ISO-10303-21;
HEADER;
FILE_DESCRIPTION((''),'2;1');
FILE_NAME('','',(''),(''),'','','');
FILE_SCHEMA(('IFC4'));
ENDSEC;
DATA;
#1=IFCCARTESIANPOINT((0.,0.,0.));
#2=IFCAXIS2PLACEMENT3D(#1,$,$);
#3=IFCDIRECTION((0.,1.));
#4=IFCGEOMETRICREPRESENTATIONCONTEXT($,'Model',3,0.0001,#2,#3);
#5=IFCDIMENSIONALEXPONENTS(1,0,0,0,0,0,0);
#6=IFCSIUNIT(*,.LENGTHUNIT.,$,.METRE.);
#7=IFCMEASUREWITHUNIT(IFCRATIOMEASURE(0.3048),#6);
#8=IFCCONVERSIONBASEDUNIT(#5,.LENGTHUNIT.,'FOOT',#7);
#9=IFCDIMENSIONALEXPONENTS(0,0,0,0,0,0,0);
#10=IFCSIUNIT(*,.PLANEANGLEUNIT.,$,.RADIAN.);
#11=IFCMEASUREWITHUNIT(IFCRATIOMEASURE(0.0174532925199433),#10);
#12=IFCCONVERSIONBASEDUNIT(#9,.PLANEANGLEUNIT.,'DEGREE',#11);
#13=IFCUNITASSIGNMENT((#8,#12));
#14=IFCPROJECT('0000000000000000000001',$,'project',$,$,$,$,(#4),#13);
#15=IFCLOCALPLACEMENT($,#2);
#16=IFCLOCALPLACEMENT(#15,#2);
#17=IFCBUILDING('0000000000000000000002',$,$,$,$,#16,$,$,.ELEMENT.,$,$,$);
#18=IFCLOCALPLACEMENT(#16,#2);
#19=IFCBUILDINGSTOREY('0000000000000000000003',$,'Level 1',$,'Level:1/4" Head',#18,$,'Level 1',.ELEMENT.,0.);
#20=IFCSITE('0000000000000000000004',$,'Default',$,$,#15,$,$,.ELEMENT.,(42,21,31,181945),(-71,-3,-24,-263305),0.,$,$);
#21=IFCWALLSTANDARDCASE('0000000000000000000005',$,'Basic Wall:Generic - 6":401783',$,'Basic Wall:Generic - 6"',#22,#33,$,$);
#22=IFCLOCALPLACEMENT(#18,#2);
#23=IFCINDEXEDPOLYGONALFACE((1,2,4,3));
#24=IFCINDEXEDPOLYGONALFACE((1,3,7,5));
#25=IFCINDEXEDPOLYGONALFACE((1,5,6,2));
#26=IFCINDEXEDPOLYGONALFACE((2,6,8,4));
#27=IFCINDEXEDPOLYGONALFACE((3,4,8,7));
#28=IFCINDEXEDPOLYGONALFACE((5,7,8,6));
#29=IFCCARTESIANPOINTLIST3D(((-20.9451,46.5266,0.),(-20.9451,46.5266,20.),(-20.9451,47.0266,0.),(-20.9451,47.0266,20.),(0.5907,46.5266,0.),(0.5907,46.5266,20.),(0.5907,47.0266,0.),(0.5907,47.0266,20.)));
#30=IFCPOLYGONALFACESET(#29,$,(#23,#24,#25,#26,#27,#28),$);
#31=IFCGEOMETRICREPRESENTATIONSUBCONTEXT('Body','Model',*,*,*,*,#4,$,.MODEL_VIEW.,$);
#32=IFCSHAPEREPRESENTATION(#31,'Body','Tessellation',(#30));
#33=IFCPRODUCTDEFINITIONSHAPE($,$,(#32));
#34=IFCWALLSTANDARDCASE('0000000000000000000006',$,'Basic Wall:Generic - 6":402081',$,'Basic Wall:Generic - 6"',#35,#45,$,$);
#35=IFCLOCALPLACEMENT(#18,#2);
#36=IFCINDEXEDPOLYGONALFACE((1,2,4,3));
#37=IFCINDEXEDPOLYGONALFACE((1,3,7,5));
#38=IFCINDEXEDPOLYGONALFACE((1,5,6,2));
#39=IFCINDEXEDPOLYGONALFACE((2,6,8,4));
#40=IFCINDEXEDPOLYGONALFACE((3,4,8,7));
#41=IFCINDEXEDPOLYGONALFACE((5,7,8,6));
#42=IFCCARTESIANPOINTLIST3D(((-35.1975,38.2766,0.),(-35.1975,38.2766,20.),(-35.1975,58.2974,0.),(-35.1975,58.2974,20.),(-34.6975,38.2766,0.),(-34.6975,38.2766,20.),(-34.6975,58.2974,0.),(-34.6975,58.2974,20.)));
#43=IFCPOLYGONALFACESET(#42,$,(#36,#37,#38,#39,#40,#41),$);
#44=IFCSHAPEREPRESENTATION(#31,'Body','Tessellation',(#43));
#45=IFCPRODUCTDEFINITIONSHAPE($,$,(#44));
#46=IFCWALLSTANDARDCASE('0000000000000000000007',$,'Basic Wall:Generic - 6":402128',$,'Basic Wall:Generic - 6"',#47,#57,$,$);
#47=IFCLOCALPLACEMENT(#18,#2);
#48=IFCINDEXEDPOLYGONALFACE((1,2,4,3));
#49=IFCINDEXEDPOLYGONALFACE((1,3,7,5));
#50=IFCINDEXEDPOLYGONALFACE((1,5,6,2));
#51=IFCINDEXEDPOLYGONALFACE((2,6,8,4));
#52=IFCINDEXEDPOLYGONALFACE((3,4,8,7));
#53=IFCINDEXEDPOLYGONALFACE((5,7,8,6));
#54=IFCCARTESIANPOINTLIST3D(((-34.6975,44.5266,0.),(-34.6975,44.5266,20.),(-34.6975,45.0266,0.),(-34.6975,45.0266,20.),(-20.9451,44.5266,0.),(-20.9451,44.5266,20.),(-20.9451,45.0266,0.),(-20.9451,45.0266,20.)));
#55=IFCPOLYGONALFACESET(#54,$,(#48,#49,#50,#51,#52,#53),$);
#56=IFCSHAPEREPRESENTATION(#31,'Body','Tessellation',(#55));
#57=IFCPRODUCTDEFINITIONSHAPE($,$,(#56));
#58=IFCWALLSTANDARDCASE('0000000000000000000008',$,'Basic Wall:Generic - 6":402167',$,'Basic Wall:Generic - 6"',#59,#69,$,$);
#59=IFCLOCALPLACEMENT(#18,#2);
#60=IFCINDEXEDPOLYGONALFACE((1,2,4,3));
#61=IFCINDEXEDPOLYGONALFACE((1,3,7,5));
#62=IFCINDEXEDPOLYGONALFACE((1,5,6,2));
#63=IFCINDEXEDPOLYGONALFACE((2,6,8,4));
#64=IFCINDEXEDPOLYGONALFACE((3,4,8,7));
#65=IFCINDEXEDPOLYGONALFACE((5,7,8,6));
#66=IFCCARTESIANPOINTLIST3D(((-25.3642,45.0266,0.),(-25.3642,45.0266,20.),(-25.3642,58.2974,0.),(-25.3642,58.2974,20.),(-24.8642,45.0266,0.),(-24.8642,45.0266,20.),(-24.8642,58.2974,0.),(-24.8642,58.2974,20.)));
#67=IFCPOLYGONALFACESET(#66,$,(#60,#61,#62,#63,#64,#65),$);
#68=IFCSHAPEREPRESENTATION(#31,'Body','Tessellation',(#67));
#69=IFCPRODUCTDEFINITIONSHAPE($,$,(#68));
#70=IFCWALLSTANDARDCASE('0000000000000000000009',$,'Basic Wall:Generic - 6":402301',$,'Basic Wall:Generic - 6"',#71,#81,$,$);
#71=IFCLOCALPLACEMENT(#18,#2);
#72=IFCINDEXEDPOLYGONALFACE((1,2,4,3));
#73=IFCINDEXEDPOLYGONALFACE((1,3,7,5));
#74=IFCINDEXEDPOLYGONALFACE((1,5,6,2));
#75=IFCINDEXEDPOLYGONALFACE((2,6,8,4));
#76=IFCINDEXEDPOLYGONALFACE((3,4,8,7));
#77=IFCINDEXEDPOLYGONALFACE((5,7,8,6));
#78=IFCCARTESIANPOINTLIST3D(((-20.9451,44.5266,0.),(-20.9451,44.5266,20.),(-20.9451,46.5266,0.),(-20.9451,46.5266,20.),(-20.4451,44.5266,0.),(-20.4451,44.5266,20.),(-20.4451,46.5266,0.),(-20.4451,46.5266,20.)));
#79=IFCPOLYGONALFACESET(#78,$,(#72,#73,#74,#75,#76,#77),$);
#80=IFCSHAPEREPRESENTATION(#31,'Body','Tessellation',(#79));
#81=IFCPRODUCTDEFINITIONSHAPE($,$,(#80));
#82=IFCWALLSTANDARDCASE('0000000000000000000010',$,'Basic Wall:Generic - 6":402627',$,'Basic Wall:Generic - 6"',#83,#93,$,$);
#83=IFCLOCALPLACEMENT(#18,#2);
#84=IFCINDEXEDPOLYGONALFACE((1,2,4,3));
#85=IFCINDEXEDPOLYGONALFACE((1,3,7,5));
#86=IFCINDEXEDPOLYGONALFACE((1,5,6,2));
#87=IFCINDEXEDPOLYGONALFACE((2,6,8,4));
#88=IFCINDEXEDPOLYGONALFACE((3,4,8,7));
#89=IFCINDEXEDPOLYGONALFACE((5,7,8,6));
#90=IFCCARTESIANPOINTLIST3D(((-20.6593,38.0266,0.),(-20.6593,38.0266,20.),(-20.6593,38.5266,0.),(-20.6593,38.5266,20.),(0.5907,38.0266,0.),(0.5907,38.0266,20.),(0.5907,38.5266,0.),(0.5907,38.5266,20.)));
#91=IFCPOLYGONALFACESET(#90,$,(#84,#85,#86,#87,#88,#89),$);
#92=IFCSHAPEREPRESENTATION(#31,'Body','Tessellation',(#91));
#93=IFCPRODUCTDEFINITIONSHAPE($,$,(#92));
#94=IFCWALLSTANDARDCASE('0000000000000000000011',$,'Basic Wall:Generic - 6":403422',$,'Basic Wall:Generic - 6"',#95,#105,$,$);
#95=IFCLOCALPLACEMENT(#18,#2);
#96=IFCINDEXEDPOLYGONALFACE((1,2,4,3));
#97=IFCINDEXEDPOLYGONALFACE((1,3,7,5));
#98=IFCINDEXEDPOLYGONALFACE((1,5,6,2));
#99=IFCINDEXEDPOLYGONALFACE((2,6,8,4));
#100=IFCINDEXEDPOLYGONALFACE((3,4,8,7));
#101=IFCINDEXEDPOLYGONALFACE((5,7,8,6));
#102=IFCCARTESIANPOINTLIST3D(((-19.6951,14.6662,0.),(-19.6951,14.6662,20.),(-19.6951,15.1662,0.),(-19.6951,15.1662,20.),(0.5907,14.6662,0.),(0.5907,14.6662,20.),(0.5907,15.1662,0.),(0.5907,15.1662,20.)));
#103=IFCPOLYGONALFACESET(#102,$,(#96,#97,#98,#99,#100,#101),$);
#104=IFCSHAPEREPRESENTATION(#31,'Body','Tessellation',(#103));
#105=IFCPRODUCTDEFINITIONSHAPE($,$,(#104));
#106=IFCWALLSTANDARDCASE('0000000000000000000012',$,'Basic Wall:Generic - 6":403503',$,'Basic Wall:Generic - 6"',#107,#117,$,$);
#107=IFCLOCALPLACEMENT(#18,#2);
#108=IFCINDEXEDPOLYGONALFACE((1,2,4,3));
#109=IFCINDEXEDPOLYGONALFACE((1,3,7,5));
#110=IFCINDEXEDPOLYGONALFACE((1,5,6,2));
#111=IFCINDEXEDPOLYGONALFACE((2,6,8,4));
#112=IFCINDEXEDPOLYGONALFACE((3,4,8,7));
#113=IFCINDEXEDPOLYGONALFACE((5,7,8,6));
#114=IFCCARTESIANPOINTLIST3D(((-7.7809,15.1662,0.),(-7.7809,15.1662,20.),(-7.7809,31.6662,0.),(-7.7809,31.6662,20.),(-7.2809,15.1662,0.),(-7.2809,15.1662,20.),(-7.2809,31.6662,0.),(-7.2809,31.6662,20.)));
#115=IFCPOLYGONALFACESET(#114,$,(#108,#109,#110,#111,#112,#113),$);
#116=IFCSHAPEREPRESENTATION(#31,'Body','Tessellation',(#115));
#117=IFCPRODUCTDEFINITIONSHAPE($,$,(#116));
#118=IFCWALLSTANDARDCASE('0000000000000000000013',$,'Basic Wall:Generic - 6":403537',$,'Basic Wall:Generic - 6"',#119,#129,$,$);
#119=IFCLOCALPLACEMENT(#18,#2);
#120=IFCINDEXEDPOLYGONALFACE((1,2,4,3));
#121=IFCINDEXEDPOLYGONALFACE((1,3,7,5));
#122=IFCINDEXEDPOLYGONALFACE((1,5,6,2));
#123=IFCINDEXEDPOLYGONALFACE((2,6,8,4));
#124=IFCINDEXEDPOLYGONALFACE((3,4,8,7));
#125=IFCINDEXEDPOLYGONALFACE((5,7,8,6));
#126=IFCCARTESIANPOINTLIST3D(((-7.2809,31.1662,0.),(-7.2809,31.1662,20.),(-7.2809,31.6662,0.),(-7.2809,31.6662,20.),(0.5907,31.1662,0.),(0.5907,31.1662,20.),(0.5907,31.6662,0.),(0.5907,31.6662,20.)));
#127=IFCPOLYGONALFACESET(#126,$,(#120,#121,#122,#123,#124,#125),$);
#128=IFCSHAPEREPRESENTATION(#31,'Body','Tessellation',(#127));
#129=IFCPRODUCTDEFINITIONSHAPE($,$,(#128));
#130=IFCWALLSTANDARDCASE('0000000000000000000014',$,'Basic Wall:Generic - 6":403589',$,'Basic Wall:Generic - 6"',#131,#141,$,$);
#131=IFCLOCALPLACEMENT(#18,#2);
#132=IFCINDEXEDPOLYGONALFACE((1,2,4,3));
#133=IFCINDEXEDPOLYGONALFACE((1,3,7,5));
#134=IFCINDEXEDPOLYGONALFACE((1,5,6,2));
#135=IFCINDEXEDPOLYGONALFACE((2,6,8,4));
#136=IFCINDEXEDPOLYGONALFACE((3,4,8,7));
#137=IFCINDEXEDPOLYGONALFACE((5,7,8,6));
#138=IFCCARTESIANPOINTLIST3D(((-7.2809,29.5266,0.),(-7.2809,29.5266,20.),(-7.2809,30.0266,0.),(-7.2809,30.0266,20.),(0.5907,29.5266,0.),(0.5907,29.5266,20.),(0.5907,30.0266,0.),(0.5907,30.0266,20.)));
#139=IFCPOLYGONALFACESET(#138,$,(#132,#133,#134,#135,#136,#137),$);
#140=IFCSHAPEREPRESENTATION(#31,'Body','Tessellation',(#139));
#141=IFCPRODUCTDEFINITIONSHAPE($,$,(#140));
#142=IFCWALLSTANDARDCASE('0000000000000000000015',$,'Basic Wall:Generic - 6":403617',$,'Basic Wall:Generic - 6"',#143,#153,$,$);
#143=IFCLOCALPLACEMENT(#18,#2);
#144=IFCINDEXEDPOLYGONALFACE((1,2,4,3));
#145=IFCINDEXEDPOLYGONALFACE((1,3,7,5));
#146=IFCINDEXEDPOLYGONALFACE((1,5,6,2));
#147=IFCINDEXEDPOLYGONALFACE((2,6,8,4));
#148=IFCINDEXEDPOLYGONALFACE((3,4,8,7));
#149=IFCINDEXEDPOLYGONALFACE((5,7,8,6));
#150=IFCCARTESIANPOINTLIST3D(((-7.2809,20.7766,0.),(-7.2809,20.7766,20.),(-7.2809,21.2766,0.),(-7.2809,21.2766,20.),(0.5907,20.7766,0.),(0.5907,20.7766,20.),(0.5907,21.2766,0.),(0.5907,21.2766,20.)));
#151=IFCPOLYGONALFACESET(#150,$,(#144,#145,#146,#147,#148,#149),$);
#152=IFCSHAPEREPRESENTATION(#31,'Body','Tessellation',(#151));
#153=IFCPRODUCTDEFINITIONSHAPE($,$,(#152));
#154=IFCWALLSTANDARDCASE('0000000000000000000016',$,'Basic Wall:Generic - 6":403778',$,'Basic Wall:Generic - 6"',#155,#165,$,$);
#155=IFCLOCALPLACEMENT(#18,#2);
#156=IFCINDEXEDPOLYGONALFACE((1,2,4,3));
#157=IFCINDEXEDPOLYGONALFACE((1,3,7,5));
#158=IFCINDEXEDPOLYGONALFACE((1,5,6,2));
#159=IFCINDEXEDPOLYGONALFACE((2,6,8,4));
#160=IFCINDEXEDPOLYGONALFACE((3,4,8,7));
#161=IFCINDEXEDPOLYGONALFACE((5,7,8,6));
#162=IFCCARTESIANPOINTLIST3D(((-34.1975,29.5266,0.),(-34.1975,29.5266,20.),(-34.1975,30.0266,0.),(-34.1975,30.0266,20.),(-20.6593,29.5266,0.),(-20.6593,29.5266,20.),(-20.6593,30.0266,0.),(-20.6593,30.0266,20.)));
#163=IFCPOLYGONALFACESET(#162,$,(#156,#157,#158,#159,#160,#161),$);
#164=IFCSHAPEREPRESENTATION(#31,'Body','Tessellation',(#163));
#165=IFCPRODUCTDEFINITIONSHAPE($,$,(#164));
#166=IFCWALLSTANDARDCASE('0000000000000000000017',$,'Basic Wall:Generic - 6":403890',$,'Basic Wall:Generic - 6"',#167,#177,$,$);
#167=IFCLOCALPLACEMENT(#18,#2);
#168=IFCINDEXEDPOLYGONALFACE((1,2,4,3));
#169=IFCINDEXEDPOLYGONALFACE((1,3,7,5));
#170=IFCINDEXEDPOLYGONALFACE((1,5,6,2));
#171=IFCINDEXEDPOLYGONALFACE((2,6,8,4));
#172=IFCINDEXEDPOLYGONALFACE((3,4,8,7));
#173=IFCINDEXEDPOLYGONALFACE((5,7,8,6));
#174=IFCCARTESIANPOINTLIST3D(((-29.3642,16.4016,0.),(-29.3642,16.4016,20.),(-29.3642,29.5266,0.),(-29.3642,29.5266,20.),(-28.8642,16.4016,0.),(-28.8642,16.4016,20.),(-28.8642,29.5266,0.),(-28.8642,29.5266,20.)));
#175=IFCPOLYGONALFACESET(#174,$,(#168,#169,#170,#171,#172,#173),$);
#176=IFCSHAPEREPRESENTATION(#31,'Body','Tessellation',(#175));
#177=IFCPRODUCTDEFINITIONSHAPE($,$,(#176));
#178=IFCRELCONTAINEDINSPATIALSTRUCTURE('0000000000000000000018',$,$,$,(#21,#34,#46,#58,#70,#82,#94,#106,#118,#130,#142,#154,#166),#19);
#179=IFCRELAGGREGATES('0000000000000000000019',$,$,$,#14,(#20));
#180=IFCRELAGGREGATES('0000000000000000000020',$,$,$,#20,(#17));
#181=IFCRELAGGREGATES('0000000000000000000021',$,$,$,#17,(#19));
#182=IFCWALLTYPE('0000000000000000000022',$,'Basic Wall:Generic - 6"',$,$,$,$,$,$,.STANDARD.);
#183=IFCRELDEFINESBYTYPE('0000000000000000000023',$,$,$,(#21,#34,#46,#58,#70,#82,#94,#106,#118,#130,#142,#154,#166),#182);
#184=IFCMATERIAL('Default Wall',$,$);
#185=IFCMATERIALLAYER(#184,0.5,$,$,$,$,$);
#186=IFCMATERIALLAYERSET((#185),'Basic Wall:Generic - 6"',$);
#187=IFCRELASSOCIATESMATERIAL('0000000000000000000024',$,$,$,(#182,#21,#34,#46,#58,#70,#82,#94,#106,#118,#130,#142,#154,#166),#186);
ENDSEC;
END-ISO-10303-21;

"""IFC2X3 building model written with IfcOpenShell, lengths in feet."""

from ifc_helpers import new_model, entity, si_unit, converted_unit, direction, frame, frame_2d, origin, place, context, subcontext, project, spatial, rectangle, extrude, material, layer, layer_set, layer_usage, type_object, element, save


model = new_model("IFC2X3")

# Units and contexts
model_context = context("Model", 3, precision=0.0001, world=origin(), true_north=direction((0.0, 1.0)))
body_context = subcontext(model_context, "Body", "Model", "MODEL_VIEW")
ifc_project = project(units=[converted_unit("LENGTHUNIT", "FOOT", entity("IfcRatioMeasure", 0.3048), si_unit("LENGTHUNIT", "METRE"), dimensions=[1, 0, 0, 0, 0, 0, 0]), converted_unit("PLANEANGLEUNIT", "DEGREE", entity("IfcRatioMeasure", 0.0174532925199433), si_unit("PLANEANGLEUNIT", "RADIAN"), dimensions=[0, 0, 0, 0, 0, 0, 0])], contexts=[model_context])

# Site, building, storey
site_placement = place(None, origin())
site = spatial("IfcSite", under=ifc_project, at=site_placement, Name="Default", CompositionType="ELEMENT", RefLatitude=(42, 21, 31, 181945), RefLongitude=(-71, -3, -24, -263305), RefElevation=0.0)
building_placement = place(site_placement, origin())
building = spatial("IfcBuilding", under=site, at=building_placement, CompositionType="ELEMENT")
storey_placement = place(building_placement, origin())
storey = spatial("IfcBuildingStorey", under=building, at=storey_placement, Name="Level 1", ObjectType="Level:1/4\" Head", LongName="Level 1", CompositionType="ELEMENT", Elevation=0.0)

# Walls
ifc_material = material(Name="Default Wall")
ifc_layer_1 = layer(ifc_material, 0.5)
ifc_layer_set_1 = layer_set([ifc_layer_1], Name="Basic Wall:Generic - 6\"")
wall_type_1 = type_object("IfcWallType", Name="Basic Wall:Generic - 6\"", PredefinedType="STANDARD", material=ifc_layer_set_1)
ifc_layer_usage_1 = layer_usage(ifc_layer_set_1, "AXIS2", "NEGATIVE", 0.25)
wall_1_placement = place(storey_placement, frame((-20.9451, 46.7766, 0.0)))
element("IfcWallStandardCase", 1, at=wall_1_placement, inside=storey, type_object=wall_type_1, material=ifc_layer_usage_1, Name="Basic Wall:Generic - 6\":401783", ObjectType="Basic Wall:Generic - 6\"", context=body_context, shape_type="SweptSolid", body=[
    extrude(rectangle(XDim=21.5358, YDim=0.5, at=frame_2d((10.7679, 0.0), x_axis=(-1.0, 0.0))), origin(), (0.0, 0.0, 1.0), 20.0),
])
ifc_layer_usage_2 = layer_usage(ifc_layer_set_1, "AXIS2", "NEGATIVE", 0.25)
wall_2_placement = place(storey_placement, frame((-34.9475, 58.2974, 0.0), z_axis=(0.0, 0.0, 1.0), x_axis=(0.0, -1.0, 0.0)))
element("IfcWallStandardCase", 2, at=wall_2_placement, inside=storey, type_object=wall_type_1, material=ifc_layer_usage_2, Name="Basic Wall:Generic - 6\":402081", ObjectType="Basic Wall:Generic - 6\"", context=body_context, shape_type="SweptSolid", body=[
    extrude(rectangle(XDim=20.0208, YDim=0.5, at=frame_2d((10.0104, 0.0), x_axis=(-1.0, 0.0))), origin(), (0.0, 0.0, 1.0), 20.0),
])
ifc_layer_usage_3 = layer_usage(ifc_layer_set_1, "AXIS2", "NEGATIVE", 0.25)
wall_3_placement = place(storey_placement, frame((-34.6975, 44.7766, 0.0)))
element("IfcWallStandardCase", 3, at=wall_3_placement, inside=storey, type_object=wall_type_1, material=ifc_layer_usage_3, Name="Basic Wall:Generic - 6\":402128", ObjectType="Basic Wall:Generic - 6\"", context=body_context, shape_type="SweptSolid", body=[
    extrude(rectangle(XDim=13.7524, YDim=0.5, at=frame_2d((6.8762, 0.0), x_axis=(-1.0, 0.0))), origin(), (0.0, 0.0, 1.0), 20.0),
])
ifc_layer_usage_4 = layer_usage(ifc_layer_set_1, "AXIS2", "NEGATIVE", 0.25)
wall_4_placement = place(storey_placement, frame((-25.1142, 45.0266, 0.0), z_axis=(0.0, 0.0, 1.0), x_axis=(0.0, 1.0, 0.0)))
element("IfcWallStandardCase", 4, at=wall_4_placement, inside=storey, type_object=wall_type_1, material=ifc_layer_usage_4, Name="Basic Wall:Generic - 6\":402167", ObjectType="Basic Wall:Generic - 6\"", context=body_context, shape_type="SweptSolid", body=[
    extrude(rectangle(XDim=13.2708, YDim=0.5, at=frame_2d((6.6354, 0.0), x_axis=(-1.0, 0.0))), origin(), (0.0, 0.0, 1.0), 20.0),
])
ifc_layer_usage_5 = layer_usage(ifc_layer_set_1, "AXIS2", "NEGATIVE", 0.25)
wall_5_placement = place(storey_placement, frame((-20.6951, 46.5266, 0.0), z_axis=(0.0, 0.0, 1.0), x_axis=(0.0, -1.0, 0.0)))
element("IfcWallStandardCase", 5, at=wall_5_placement, inside=storey, type_object=wall_type_1, material=ifc_layer_usage_5, Name="Basic Wall:Generic - 6\":402301", ObjectType="Basic Wall:Generic - 6\"", context=body_context, shape_type="SweptSolid", body=[
    extrude(rectangle(XDim=2.0, YDim=0.5, at=frame_2d((1.0, 0.0), x_axis=(-1.0, 0.0))), origin(), (0.0, 0.0, 1.0), 20.0),
])
ifc_layer_usage_6 = layer_usage(ifc_layer_set_1, "AXIS2", "NEGATIVE", 0.25)
wall_6_placement = place(storey_placement, frame((0.5907, 38.2766, 0.0), z_axis=(0.0, 0.0, 1.0), x_axis=(-1.0, 0.0, 0.0)))
element("IfcWallStandardCase", 6, at=wall_6_placement, inside=storey, type_object=wall_type_1, material=ifc_layer_usage_6, Name="Basic Wall:Generic - 6\":402627", ObjectType="Basic Wall:Generic - 6\"", context=body_context, shape_type="SweptSolid", body=[
    extrude(rectangle(XDim=21.25, YDim=0.5, at=frame_2d((10.625, 0.0), x_axis=(-1.0, 0.0))), origin(), (0.0, 0.0, 1.0), 20.0),
])
ifc_layer_usage_7 = layer_usage(ifc_layer_set_1, "AXIS2", "NEGATIVE", 0.25)
wall_7_placement = place(storey_placement, frame((0.5907, 14.9162, 0.0), z_axis=(0.0, 0.0, 1.0), x_axis=(-1.0, 0.0, 0.0)))
element("IfcWallStandardCase", 7, at=wall_7_placement, inside=storey, type_object=wall_type_1, material=ifc_layer_usage_7, Name="Basic Wall:Generic - 6\":403422", ObjectType="Basic Wall:Generic - 6\"", context=body_context, shape_type="SweptSolid", body=[
    extrude(rectangle(XDim=20.2858, YDim=0.5, at=frame_2d((10.1429, 0.0), x_axis=(-1.0, 0.0))), origin(), (0.0, 0.0, 1.0), 20.0),
])
ifc_layer_usage_8 = layer_usage(ifc_layer_set_1, "AXIS2", "NEGATIVE", 0.25)
wall_8_placement = place(storey_placement, frame((-7.5309, 15.1662, 0.0), z_axis=(0.0, 0.0, 1.0), x_axis=(0.0, 1.0, 0.0)))
element("IfcWallStandardCase", 8, at=wall_8_placement, inside=storey, type_object=wall_type_1, material=ifc_layer_usage_8, Name="Basic Wall:Generic - 6\":403503", ObjectType="Basic Wall:Generic - 6\"", context=body_context, shape_type="SweptSolid", body=[
    extrude(rectangle(XDim=16.5, YDim=0.5, at=frame_2d((8.25, 0.0), x_axis=(-1.0, 0.0))), origin(), (0.0, 0.0, 1.0), 20.0),
])
ifc_layer_usage_9 = layer_usage(ifc_layer_set_1, "AXIS2", "NEGATIVE", 0.25)
wall_9_placement = place(storey_placement, frame((-7.2809, 31.4162, 0.0)))
element("IfcWallStandardCase", 9, at=wall_9_placement, inside=storey, type_object=wall_type_1, material=ifc_layer_usage_9, Name="Basic Wall:Generic - 6\":403537", ObjectType="Basic Wall:Generic - 6\"", context=body_context, shape_type="SweptSolid", body=[
    extrude(rectangle(XDim=7.8716, YDim=0.5, at=frame_2d((3.9358, 0.0), x_axis=(-1.0, 0.0))), origin(), (0.0, 0.0, 1.0), 20.0),
])
ifc_layer_usage_10 = layer_usage(ifc_layer_set_1, "AXIS2", "NEGATIVE", 0.25)
wall_10_placement = place(storey_placement, frame((0.5907, 29.7766, 0.0), z_axis=(0.0, 0.0, 1.0), x_axis=(-1.0, 0.0, 0.0)))
element("IfcWallStandardCase", 10, at=wall_10_placement, inside=storey, type_object=wall_type_1, material=ifc_layer_usage_10, Name="Basic Wall:Generic - 6\":403589", ObjectType="Basic Wall:Generic - 6\"", context=body_context, shape_type="SweptSolid", body=[
    extrude(rectangle(XDim=7.8716, YDim=0.5, at=frame_2d((3.9358, 0.0), x_axis=(-1.0, 0.0))), origin(), (0.0, 0.0, 1.0), 20.0),
])
ifc_layer_usage_11 = layer_usage(ifc_layer_set_1, "AXIS2", "NEGATIVE", 0.25)
wall_11_placement = place(storey_placement, frame((-7.2809, 21.0266, 0.0)))
element("IfcWallStandardCase", 11, at=wall_11_placement, inside=storey, type_object=wall_type_1, material=ifc_layer_usage_11, Name="Basic Wall:Generic - 6\":403617", ObjectType="Basic Wall:Generic - 6\"", context=body_context, shape_type="SweptSolid", body=[
    extrude(rectangle(XDim=7.8716, YDim=0.5, at=frame_2d((3.9358, 0.0), x_axis=(-1.0, 0.0))), origin(), (0.0, 0.0, 1.0), 20.0),
])
ifc_layer_usage_12 = layer_usage(ifc_layer_set_1, "AXIS2", "NEGATIVE", 0.25)
wall_12_placement = place(storey_placement, frame((-20.6593, 29.7766, 0.0), z_axis=(0.0, 0.0, 1.0), x_axis=(-1.0, 0.0, 0.0)))
element("IfcWallStandardCase", 12, at=wall_12_placement, inside=storey, type_object=wall_type_1, material=ifc_layer_usage_12, Name="Basic Wall:Generic - 6\":403778", ObjectType="Basic Wall:Generic - 6\"", context=body_context, shape_type="SweptSolid", body=[
    extrude(rectangle(XDim=13.5383, YDim=0.5, at=frame_2d((6.7691, 0.0), x_axis=(-1.0, 0.0))), origin(), (0.0, 0.0, 1.0), 20.0),
])
ifc_layer_usage_13 = layer_usage(ifc_layer_set_1, "AXIS2", "NEGATIVE", 0.25)
wall_13_placement = place(storey_placement, frame((-29.1142, 16.4016, 0.0), z_axis=(0.0, 0.0, 1.0), x_axis=(0.0, 1.0, 0.0)))
element("IfcWallStandardCase", 13, at=wall_13_placement, inside=storey, type_object=wall_type_1, material=ifc_layer_usage_13, Name="Basic Wall:Generic - 6\":403890", ObjectType="Basic Wall:Generic - 6\"", context=body_context, shape_type="SweptSolid", body=[
    extrude(rectangle(XDim=13.125, YDim=0.5, at=frame_2d((6.5625, 0.0), x_axis=(-1.0, 0.0))), origin(), (0.0, 0.0, 1.0), 20.0),
])

save(model, "model.ifc")
